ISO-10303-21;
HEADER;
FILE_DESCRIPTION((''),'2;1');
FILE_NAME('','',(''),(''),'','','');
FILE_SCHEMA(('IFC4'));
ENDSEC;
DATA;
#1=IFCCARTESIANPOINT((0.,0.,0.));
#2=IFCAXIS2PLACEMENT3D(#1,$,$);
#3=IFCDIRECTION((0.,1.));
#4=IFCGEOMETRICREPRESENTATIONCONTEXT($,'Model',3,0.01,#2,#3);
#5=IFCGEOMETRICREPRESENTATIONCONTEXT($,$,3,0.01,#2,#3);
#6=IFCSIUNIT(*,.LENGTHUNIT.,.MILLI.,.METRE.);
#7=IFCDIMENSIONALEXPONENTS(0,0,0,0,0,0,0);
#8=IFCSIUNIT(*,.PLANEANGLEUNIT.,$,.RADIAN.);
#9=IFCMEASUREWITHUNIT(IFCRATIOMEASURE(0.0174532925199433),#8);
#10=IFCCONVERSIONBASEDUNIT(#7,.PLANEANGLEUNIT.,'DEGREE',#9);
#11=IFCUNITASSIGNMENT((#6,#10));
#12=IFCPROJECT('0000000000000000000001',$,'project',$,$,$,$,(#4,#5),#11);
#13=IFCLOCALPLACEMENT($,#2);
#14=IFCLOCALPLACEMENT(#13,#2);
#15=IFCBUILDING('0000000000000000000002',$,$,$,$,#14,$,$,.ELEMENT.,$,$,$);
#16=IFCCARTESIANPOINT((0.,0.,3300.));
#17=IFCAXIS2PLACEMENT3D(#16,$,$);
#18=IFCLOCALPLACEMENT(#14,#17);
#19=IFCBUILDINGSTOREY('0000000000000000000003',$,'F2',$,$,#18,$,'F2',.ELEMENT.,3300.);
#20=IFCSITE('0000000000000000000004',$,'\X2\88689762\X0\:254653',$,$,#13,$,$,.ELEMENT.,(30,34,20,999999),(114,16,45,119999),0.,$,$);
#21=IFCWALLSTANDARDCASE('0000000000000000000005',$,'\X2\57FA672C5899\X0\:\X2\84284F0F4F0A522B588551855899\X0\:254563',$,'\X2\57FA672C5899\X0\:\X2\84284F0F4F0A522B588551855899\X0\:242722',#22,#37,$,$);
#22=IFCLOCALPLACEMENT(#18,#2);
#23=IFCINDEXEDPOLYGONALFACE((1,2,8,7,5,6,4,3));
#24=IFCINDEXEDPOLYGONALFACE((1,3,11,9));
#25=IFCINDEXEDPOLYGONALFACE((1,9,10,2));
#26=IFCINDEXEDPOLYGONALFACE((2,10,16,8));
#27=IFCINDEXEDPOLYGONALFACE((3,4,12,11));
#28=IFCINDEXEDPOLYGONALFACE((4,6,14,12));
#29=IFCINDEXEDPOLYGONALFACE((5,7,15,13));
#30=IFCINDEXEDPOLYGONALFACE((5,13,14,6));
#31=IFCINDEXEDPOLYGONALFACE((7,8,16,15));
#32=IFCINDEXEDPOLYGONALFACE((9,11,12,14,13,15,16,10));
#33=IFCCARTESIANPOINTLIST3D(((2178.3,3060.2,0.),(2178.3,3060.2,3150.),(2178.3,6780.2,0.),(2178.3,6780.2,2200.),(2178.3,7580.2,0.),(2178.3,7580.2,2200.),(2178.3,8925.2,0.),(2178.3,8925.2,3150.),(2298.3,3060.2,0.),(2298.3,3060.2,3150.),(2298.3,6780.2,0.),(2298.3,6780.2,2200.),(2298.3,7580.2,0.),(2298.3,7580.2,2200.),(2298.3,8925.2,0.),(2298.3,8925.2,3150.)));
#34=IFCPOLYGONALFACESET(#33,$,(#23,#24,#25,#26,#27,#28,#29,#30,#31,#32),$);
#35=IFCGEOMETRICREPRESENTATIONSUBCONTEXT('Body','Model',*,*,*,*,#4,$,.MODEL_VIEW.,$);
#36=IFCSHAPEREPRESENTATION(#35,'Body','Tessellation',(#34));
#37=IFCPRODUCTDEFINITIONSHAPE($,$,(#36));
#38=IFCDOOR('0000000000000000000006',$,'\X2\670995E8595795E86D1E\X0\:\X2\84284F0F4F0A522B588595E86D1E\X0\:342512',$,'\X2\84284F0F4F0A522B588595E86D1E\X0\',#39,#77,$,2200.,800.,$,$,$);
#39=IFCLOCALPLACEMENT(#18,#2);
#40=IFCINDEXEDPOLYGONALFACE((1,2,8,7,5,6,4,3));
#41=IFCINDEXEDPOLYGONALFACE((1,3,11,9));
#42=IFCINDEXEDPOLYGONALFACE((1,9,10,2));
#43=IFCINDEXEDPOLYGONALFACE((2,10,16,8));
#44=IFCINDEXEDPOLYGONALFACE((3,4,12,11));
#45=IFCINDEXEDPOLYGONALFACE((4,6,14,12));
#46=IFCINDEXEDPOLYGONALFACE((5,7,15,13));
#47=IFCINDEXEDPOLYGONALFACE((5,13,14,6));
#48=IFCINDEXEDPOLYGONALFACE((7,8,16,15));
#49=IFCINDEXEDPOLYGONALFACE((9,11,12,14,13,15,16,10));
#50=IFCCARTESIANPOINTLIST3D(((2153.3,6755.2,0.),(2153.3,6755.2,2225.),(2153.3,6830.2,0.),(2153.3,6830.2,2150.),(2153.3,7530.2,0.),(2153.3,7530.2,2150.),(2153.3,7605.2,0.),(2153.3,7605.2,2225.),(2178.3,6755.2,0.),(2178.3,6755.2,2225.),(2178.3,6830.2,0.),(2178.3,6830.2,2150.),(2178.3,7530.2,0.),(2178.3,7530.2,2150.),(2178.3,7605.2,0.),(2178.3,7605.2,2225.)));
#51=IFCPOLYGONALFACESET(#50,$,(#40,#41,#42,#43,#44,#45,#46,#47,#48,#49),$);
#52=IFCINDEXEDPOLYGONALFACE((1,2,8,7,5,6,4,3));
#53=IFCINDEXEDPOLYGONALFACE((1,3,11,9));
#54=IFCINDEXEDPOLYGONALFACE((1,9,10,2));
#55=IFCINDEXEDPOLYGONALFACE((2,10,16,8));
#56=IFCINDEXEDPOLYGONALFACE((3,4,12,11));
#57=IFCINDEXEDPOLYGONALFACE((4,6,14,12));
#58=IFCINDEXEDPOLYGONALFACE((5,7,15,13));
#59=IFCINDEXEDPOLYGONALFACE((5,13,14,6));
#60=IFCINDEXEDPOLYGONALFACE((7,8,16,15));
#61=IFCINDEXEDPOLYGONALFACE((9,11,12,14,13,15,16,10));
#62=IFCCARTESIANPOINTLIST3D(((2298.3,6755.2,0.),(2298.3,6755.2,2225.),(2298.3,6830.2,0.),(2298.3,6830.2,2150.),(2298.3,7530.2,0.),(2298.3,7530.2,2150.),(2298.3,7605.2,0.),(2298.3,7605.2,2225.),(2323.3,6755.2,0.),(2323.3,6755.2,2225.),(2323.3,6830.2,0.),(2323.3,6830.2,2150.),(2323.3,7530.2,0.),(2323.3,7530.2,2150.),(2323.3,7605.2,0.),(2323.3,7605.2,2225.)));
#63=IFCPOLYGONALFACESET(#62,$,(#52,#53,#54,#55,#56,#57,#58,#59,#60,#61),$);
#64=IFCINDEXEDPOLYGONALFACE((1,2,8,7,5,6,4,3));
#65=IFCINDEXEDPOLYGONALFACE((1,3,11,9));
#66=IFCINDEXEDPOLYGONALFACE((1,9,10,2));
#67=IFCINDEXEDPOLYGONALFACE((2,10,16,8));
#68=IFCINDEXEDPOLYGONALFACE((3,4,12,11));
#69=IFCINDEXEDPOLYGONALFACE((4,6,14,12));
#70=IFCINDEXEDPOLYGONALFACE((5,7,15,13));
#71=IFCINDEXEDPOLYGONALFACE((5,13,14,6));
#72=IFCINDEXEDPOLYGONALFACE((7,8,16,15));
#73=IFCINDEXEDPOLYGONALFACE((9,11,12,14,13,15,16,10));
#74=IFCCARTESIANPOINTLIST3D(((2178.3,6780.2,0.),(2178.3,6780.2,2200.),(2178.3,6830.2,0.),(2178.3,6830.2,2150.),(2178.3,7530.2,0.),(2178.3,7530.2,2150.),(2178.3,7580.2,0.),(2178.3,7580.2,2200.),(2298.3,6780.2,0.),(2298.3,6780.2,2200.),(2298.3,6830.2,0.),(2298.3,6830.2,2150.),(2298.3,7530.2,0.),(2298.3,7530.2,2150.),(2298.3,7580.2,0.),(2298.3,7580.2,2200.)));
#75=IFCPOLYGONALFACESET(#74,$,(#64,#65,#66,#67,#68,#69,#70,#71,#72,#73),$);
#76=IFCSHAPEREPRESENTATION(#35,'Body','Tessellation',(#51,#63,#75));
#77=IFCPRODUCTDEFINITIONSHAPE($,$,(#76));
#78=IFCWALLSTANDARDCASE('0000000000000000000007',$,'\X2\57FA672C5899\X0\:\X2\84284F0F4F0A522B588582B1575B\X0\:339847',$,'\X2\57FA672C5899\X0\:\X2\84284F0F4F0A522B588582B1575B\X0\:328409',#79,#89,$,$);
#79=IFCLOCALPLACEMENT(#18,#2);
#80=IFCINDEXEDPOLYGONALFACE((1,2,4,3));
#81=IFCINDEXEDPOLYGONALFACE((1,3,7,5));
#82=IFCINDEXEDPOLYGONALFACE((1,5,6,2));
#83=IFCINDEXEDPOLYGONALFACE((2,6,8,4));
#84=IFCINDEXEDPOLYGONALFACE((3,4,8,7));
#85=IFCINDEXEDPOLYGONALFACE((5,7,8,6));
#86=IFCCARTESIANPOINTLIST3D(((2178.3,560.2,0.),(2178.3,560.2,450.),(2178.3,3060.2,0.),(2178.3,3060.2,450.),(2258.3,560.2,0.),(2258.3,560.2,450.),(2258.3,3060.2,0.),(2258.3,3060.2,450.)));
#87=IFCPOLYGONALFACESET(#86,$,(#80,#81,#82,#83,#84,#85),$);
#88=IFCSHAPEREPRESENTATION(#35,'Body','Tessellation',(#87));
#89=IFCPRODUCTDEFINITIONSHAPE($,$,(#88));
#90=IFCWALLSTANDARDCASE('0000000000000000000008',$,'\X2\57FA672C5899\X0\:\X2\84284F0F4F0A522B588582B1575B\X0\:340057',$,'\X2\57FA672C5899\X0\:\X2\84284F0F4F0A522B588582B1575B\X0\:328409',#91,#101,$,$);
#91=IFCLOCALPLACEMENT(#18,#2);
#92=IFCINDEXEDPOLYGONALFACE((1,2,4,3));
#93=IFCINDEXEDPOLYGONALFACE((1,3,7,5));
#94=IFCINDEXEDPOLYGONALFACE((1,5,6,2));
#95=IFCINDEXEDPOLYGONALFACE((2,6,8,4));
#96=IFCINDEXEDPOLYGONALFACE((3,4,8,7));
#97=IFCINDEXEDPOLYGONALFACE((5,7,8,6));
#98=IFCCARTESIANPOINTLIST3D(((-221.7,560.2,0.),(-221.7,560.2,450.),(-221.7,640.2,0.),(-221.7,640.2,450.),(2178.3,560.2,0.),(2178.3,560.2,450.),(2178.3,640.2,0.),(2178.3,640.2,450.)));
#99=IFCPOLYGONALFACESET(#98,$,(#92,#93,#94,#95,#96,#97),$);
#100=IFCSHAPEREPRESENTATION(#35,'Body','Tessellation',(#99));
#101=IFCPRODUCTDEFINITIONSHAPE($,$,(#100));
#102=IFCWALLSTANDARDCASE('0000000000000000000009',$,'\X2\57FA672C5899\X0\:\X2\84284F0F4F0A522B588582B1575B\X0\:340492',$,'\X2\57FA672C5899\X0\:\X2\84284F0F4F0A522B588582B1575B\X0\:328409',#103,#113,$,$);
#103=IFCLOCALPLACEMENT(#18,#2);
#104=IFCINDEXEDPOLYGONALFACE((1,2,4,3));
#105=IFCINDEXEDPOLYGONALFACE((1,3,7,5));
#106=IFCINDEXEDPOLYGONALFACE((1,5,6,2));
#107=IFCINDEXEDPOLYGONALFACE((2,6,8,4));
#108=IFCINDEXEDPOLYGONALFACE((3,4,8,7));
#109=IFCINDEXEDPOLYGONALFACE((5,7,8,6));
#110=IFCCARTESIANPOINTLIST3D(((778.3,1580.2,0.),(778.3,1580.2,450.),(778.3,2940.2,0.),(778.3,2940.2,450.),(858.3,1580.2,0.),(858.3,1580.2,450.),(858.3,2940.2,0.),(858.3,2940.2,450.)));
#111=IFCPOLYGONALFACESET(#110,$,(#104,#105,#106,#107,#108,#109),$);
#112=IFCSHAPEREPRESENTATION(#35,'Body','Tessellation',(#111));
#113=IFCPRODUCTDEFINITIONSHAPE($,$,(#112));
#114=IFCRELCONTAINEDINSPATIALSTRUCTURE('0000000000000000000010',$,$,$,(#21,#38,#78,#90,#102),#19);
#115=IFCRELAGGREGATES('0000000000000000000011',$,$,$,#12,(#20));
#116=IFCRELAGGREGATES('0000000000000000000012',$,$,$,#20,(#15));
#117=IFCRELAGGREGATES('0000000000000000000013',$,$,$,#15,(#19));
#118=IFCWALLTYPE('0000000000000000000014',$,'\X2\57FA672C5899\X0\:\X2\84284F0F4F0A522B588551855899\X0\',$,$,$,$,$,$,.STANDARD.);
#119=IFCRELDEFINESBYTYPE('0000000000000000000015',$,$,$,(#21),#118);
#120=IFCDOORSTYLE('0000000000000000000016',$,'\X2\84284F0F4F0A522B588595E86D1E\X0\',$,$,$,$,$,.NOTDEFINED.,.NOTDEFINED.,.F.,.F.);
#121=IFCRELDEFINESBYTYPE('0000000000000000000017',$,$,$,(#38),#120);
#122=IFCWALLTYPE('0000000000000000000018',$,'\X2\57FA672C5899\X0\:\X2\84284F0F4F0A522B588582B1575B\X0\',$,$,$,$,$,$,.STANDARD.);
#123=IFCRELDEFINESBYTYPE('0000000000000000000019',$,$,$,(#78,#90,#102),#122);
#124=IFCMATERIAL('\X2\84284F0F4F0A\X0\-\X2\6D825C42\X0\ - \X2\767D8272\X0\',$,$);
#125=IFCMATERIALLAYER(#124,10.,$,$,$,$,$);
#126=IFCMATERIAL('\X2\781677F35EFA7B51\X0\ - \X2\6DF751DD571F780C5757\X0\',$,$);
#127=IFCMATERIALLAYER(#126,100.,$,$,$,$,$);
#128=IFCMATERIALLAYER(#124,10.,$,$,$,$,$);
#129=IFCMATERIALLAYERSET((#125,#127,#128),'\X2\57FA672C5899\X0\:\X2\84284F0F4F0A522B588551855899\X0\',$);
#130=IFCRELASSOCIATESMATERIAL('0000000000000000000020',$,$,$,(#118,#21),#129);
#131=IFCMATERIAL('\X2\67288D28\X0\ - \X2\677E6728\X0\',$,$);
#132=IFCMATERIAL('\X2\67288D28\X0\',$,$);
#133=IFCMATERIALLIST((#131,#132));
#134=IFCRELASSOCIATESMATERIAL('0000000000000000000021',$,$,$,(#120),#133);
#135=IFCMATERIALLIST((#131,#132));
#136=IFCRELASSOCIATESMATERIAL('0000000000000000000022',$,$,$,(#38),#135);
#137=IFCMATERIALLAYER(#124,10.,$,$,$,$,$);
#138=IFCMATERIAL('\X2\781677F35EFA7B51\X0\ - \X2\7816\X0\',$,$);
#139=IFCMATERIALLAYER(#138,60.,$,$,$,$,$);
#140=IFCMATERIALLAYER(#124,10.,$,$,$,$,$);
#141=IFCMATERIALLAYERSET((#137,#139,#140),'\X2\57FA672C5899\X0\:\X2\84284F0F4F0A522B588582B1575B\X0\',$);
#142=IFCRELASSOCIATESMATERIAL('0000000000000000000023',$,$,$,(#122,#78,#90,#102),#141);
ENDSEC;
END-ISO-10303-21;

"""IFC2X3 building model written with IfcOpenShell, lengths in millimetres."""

from ifc_helpers import new_model, entity, si_unit, converted_unit, direction, frame, frame_2d, origin, place, context, subcontext, project, spatial, polyline, rectangle, outline, extrude, clip, bounded_halfspace, source, transform, mapped, material, material_list, layer, layer_set, layer_usage, type_object, type_shapes, element, fill, save


model = new_model("IFC2X3")

# Units and contexts
model_context = context("Model", 3, precision=0.01, world=origin(), true_north=direction((0.0, 1.0)))
context_of_model = context(None, 3, precision=0.01, world=origin(), true_north=direction((0.0, 1.0)))
body_context = subcontext(model_context, "Body", "Model", "MODEL_VIEW")
ifc_project = project(units=[si_unit("LENGTHUNIT", "METRE", prefix="MILLI"), converted_unit("PLANEANGLEUNIT", "DEGREE", entity("IfcRatioMeasure", 0.0174532925199433), si_unit("PLANEANGLEUNIT", "RADIAN"), dimensions=[0, 0, 0, 0, 0, 0, 0])], contexts=[model_context, context_of_model])

# Site, building, storey
site_placement = place(None, origin())
site = spatial("IfcSite", under=ifc_project, at=site_placement, Name="表面:254653", CompositionType="ELEMENT", RefLatitude=(30, 34, 20, 999999), RefLongitude=(114, 16, 45, 119999), RefElevation=0.0)
building_placement = place(site_placement, origin())
building = spatial("IfcBuilding", under=site, at=building_placement, CompositionType="ELEMENT")
storey_placement = place(building_placement, frame((0.0, 0.0, 3300.0)))
storey = spatial("IfcBuildingStorey", under=building, at=storey_placement, Name="F2", LongName="F2", CompositionType="ELEMENT", Elevation=3300.0)

# Wall, opening, door
ifc_material_1 = material(Name="萨伏伊-涂层 - 白色")
ifc_layer_1 = layer(ifc_material_1, 10.0)
ifc_material_2 = material(Name="砖石建筑 - 混凝土砌块")
ifc_layer_2 = layer(ifc_material_2, 100.0)
ifc_layer_3 = layer(ifc_material_1, 10.0)
ifc_layer_set_1 = layer_set([ifc_layer_1, ifc_layer_2, ifc_layer_3], Name="基本墙:萨伏伊别墅内墙")
ifc_layer_usage_1 = layer_usage(ifc_layer_set_1, "AXIS2", "NEGATIVE", 60.0)
wall_type_1 = type_object("IfcWallType", Name="基本墙:萨伏伊别墅内墙", PredefinedType="STANDARD", material=ifc_layer_set_1)
wall_1_placement = place(storey_placement, frame((2238.3, 3060.2, 0.0), z_axis=(0.0, 0.0, 1.0), x_axis=(0.0, 1.0, 0.0)))
wall_1 = element("IfcWallStandardCase", 1, at=wall_1_placement, inside=storey, type_object=wall_type_1, material=ifc_layer_usage_1, Name="基本墙:萨伏伊别墅内墙:254563", ObjectType="基本墙:萨伏伊别墅内墙:242722", context=body_context, shape_type="Clipping", body=[
    clip(extrude(rectangle(XDim=5865.0, YDim=120.0, at=frame_2d((2932.5, 0.0), x_axis=(-1.0, 0.0))), origin(), (0.0, 0.0, 1.0), 3150.0), bounded_halfspace(frame((0.0, -60.0, 3150.0), z_axis=(0.0, 0.0, -1.0), x_axis=(-1.0, 0.0, 0.0)), True, frame((0.0, -60.0, 3150.0)), polyline([(0.0, 0.0), (5865.0, 0.0), (5865.0, 120.0), (0.0, 120.0), (0.0, 0.0)]))),
])
opening_1_placement = place(wall_1_placement, frame((3720.0, -60.0, 0.0)))
opening_1 = element("IfcOpeningElement", 2, at=opening_1_placement, cuts=wall_1, ObjectType="Opening", context=body_context, shape_type="SweptSolid", body=[
    extrude(rectangle(XDim=2200.0, YDim=800.0, at=frame_2d((1100.0, 400.0), x_axis=(1.0, 0.0))), frame((0.0, 0.0, 0.0), z_axis=(0.0, 1.0, 0.0), x_axis=(0.0, 0.0, 1.0)), (0.0, 0.0, 1.0), 120.0),
])
ifc_material_3 = material(Name="木质 - 松木")
ifc_material_4 = material(Name="木质")
ifc_material_list_1 = material_list([ifc_material_3, ifc_material_4])
ifc_material_list_2 = material_list([ifc_material_3, ifc_material_4])
door_style = type_object("IfcDoorStyle", Name="萨伏伊别墅门洞", ConstructionType="NOTDEFINED", OperationType="NOTDEFINED", ParameterTakesPrecedence=False, Sizeable=False, material=ifc_material_list_2)
shared_shape_1 = source(origin(), body_context, "Body", "SweptSolid", [
    extrude(outline(polyline([(-425.0, -1131.2), (425.0, -1131.2), (425.0, 1093.7), (350.0, 1093.7), (350.0, -1056.2), (-350.0, -1056.2), (-350.0, 1093.7), (-425.0, 1093.7), (-425.0, -1131.2)])), frame((400.0, 120.0, 1093.7), z_axis=(0.0, 1.0, 0.0), x_axis=(1.0, 0.0, 0.0)), (0.0, 0.0, 1.0), 25.0),
    extrude(outline(polyline([(-425.0, -1131.2), (425.0, -1131.2), (425.0, 1093.7), (350.0, 1093.7), (350.0, -1056.2), (-350.0, -1056.2), (-350.0, 1093.7), (-425.0, 1093.7), (-425.0, -1131.2)])), frame((400.0, -25.0, 1093.7), z_axis=(0.0, 1.0, 0.0), x_axis=(1.0, 0.0, 0.0)), (0.0, 0.0, 1.0), 25.0),
    extrude(outline(polyline([(-400.0, -1112.5), (400.0, -1112.5), (400.0, 1087.5), (350.0, 1087.5), (350.0, -1062.5), (-350.0, -1062.5), (-350.0, 1087.5), (-400.0, 1087.5), (-400.0, -1112.5)])), frame((400.0, 0.0, 1087.5), z_axis=(0.0, 1.0, 0.0), x_axis=(1.0, 0.0, 0.0)), (0.0, 0.0, 1.0), 120.0),
])
type_shapes(door_style, [shared_shape_1])
door_placement = place(opening_1_placement, origin())
door = element("IfcDoor", 3, at=door_placement, inside=storey, type_object=door_style, material=ifc_material_list_1, Name="有门套门洞:萨伏伊别墅门洞:342512", ObjectType="萨伏伊别墅门洞", OverallHeight=2200.0, OverallWidth=800.0, context=body_context, shape_type="MappedRepresentation", body=[
    mapped(shared_shape_1, transform((0.0, 0.0, 0.0), scale=1.0)),
])
fill(opening_1, door)

# Shared definitions
ifc_material_5 = material(Name="砖石建筑 - 砖")

# Walls
ifc_layer_4 = layer(ifc_material_1, 10.0)
ifc_layer_5 = layer(ifc_material_5, 60.0)
ifc_layer_6 = layer(ifc_material_1, 10.0)
ifc_layer_set_2 = layer_set([ifc_layer_4, ifc_layer_5, ifc_layer_6], Name="基本墙:萨伏伊别墅花坛")
ifc_layer_usage_2 = layer_usage(ifc_layer_set_2, "AXIS2", "NEGATIVE", 40.0)
wall_type_2 = type_object("IfcWallType", Name="基本墙:萨伏伊别墅花坛", PredefinedType="STANDARD", material=ifc_layer_set_2)
wall_2_placement = place(storey_placement, frame((2218.3, 3060.2, 0.0), z_axis=(0.0, 0.0, 1.0), x_axis=(0.0, -1.0, 0.0)))
element("IfcWallStandardCase", 4, at=wall_2_placement, inside=storey, type_object=wall_type_2, material=ifc_layer_usage_2, Name="基本墙:萨伏伊别墅花坛:339847", ObjectType="基本墙:萨伏伊别墅花坛:328409", context=body_context, shape_type="SweptSolid", body=[
    extrude(rectangle(XDim=2500.0, YDim=80.0, at=frame_2d((1250.0, 0.0), x_axis=(-1.0, 0.0))), origin(), (0.0, 0.0, 1.0), 450.0),
])
ifc_layer_usage_3 = layer_usage(ifc_layer_set_2, "AXIS2", "NEGATIVE", 40.0)
wall_3_placement = place(storey_placement, frame((2178.3, 600.2, 0.0), z_axis=(0.0, 0.0, 1.0), x_axis=(-1.0, 0.0, 0.0)))
element("IfcWallStandardCase", 5, at=wall_3_placement, inside=storey, type_object=wall_type_2, material=ifc_layer_usage_3, Name="基本墙:萨伏伊别墅花坛:340057", ObjectType="基本墙:萨伏伊别墅花坛:328409", context=body_context, shape_type="SweptSolid", body=[
    extrude(rectangle(XDim=2400.0, YDim=80.0, at=frame_2d((1200.0, 0.0), x_axis=(-1.0, 0.0))), origin(), (0.0, 0.0, 1.0), 450.0),
])
ifc_layer_usage_4 = layer_usage(ifc_layer_set_2, "AXIS2", "NEGATIVE", 40.0)
wall_4_placement = place(storey_placement, frame((818.3, 1580.2, 0.0), z_axis=(0.0, 0.0, 1.0), x_axis=(0.0, 1.0, 0.0)))
element("IfcWallStandardCase", 6, at=wall_4_placement, inside=storey, type_object=wall_type_2, material=ifc_layer_usage_4, Name="基本墙:萨伏伊别墅花坛:340492", ObjectType="基本墙:萨伏伊别墅花坛:328409", context=body_context, shape_type="SweptSolid", body=[
    extrude(rectangle(XDim=1360.0, YDim=80.0, at=frame_2d((680.0, 0.0), x_axis=(-1.0, 0.0))), origin(), (0.0, 0.0, 1.0), 450.0),
])

save(model, "model.ifc")
